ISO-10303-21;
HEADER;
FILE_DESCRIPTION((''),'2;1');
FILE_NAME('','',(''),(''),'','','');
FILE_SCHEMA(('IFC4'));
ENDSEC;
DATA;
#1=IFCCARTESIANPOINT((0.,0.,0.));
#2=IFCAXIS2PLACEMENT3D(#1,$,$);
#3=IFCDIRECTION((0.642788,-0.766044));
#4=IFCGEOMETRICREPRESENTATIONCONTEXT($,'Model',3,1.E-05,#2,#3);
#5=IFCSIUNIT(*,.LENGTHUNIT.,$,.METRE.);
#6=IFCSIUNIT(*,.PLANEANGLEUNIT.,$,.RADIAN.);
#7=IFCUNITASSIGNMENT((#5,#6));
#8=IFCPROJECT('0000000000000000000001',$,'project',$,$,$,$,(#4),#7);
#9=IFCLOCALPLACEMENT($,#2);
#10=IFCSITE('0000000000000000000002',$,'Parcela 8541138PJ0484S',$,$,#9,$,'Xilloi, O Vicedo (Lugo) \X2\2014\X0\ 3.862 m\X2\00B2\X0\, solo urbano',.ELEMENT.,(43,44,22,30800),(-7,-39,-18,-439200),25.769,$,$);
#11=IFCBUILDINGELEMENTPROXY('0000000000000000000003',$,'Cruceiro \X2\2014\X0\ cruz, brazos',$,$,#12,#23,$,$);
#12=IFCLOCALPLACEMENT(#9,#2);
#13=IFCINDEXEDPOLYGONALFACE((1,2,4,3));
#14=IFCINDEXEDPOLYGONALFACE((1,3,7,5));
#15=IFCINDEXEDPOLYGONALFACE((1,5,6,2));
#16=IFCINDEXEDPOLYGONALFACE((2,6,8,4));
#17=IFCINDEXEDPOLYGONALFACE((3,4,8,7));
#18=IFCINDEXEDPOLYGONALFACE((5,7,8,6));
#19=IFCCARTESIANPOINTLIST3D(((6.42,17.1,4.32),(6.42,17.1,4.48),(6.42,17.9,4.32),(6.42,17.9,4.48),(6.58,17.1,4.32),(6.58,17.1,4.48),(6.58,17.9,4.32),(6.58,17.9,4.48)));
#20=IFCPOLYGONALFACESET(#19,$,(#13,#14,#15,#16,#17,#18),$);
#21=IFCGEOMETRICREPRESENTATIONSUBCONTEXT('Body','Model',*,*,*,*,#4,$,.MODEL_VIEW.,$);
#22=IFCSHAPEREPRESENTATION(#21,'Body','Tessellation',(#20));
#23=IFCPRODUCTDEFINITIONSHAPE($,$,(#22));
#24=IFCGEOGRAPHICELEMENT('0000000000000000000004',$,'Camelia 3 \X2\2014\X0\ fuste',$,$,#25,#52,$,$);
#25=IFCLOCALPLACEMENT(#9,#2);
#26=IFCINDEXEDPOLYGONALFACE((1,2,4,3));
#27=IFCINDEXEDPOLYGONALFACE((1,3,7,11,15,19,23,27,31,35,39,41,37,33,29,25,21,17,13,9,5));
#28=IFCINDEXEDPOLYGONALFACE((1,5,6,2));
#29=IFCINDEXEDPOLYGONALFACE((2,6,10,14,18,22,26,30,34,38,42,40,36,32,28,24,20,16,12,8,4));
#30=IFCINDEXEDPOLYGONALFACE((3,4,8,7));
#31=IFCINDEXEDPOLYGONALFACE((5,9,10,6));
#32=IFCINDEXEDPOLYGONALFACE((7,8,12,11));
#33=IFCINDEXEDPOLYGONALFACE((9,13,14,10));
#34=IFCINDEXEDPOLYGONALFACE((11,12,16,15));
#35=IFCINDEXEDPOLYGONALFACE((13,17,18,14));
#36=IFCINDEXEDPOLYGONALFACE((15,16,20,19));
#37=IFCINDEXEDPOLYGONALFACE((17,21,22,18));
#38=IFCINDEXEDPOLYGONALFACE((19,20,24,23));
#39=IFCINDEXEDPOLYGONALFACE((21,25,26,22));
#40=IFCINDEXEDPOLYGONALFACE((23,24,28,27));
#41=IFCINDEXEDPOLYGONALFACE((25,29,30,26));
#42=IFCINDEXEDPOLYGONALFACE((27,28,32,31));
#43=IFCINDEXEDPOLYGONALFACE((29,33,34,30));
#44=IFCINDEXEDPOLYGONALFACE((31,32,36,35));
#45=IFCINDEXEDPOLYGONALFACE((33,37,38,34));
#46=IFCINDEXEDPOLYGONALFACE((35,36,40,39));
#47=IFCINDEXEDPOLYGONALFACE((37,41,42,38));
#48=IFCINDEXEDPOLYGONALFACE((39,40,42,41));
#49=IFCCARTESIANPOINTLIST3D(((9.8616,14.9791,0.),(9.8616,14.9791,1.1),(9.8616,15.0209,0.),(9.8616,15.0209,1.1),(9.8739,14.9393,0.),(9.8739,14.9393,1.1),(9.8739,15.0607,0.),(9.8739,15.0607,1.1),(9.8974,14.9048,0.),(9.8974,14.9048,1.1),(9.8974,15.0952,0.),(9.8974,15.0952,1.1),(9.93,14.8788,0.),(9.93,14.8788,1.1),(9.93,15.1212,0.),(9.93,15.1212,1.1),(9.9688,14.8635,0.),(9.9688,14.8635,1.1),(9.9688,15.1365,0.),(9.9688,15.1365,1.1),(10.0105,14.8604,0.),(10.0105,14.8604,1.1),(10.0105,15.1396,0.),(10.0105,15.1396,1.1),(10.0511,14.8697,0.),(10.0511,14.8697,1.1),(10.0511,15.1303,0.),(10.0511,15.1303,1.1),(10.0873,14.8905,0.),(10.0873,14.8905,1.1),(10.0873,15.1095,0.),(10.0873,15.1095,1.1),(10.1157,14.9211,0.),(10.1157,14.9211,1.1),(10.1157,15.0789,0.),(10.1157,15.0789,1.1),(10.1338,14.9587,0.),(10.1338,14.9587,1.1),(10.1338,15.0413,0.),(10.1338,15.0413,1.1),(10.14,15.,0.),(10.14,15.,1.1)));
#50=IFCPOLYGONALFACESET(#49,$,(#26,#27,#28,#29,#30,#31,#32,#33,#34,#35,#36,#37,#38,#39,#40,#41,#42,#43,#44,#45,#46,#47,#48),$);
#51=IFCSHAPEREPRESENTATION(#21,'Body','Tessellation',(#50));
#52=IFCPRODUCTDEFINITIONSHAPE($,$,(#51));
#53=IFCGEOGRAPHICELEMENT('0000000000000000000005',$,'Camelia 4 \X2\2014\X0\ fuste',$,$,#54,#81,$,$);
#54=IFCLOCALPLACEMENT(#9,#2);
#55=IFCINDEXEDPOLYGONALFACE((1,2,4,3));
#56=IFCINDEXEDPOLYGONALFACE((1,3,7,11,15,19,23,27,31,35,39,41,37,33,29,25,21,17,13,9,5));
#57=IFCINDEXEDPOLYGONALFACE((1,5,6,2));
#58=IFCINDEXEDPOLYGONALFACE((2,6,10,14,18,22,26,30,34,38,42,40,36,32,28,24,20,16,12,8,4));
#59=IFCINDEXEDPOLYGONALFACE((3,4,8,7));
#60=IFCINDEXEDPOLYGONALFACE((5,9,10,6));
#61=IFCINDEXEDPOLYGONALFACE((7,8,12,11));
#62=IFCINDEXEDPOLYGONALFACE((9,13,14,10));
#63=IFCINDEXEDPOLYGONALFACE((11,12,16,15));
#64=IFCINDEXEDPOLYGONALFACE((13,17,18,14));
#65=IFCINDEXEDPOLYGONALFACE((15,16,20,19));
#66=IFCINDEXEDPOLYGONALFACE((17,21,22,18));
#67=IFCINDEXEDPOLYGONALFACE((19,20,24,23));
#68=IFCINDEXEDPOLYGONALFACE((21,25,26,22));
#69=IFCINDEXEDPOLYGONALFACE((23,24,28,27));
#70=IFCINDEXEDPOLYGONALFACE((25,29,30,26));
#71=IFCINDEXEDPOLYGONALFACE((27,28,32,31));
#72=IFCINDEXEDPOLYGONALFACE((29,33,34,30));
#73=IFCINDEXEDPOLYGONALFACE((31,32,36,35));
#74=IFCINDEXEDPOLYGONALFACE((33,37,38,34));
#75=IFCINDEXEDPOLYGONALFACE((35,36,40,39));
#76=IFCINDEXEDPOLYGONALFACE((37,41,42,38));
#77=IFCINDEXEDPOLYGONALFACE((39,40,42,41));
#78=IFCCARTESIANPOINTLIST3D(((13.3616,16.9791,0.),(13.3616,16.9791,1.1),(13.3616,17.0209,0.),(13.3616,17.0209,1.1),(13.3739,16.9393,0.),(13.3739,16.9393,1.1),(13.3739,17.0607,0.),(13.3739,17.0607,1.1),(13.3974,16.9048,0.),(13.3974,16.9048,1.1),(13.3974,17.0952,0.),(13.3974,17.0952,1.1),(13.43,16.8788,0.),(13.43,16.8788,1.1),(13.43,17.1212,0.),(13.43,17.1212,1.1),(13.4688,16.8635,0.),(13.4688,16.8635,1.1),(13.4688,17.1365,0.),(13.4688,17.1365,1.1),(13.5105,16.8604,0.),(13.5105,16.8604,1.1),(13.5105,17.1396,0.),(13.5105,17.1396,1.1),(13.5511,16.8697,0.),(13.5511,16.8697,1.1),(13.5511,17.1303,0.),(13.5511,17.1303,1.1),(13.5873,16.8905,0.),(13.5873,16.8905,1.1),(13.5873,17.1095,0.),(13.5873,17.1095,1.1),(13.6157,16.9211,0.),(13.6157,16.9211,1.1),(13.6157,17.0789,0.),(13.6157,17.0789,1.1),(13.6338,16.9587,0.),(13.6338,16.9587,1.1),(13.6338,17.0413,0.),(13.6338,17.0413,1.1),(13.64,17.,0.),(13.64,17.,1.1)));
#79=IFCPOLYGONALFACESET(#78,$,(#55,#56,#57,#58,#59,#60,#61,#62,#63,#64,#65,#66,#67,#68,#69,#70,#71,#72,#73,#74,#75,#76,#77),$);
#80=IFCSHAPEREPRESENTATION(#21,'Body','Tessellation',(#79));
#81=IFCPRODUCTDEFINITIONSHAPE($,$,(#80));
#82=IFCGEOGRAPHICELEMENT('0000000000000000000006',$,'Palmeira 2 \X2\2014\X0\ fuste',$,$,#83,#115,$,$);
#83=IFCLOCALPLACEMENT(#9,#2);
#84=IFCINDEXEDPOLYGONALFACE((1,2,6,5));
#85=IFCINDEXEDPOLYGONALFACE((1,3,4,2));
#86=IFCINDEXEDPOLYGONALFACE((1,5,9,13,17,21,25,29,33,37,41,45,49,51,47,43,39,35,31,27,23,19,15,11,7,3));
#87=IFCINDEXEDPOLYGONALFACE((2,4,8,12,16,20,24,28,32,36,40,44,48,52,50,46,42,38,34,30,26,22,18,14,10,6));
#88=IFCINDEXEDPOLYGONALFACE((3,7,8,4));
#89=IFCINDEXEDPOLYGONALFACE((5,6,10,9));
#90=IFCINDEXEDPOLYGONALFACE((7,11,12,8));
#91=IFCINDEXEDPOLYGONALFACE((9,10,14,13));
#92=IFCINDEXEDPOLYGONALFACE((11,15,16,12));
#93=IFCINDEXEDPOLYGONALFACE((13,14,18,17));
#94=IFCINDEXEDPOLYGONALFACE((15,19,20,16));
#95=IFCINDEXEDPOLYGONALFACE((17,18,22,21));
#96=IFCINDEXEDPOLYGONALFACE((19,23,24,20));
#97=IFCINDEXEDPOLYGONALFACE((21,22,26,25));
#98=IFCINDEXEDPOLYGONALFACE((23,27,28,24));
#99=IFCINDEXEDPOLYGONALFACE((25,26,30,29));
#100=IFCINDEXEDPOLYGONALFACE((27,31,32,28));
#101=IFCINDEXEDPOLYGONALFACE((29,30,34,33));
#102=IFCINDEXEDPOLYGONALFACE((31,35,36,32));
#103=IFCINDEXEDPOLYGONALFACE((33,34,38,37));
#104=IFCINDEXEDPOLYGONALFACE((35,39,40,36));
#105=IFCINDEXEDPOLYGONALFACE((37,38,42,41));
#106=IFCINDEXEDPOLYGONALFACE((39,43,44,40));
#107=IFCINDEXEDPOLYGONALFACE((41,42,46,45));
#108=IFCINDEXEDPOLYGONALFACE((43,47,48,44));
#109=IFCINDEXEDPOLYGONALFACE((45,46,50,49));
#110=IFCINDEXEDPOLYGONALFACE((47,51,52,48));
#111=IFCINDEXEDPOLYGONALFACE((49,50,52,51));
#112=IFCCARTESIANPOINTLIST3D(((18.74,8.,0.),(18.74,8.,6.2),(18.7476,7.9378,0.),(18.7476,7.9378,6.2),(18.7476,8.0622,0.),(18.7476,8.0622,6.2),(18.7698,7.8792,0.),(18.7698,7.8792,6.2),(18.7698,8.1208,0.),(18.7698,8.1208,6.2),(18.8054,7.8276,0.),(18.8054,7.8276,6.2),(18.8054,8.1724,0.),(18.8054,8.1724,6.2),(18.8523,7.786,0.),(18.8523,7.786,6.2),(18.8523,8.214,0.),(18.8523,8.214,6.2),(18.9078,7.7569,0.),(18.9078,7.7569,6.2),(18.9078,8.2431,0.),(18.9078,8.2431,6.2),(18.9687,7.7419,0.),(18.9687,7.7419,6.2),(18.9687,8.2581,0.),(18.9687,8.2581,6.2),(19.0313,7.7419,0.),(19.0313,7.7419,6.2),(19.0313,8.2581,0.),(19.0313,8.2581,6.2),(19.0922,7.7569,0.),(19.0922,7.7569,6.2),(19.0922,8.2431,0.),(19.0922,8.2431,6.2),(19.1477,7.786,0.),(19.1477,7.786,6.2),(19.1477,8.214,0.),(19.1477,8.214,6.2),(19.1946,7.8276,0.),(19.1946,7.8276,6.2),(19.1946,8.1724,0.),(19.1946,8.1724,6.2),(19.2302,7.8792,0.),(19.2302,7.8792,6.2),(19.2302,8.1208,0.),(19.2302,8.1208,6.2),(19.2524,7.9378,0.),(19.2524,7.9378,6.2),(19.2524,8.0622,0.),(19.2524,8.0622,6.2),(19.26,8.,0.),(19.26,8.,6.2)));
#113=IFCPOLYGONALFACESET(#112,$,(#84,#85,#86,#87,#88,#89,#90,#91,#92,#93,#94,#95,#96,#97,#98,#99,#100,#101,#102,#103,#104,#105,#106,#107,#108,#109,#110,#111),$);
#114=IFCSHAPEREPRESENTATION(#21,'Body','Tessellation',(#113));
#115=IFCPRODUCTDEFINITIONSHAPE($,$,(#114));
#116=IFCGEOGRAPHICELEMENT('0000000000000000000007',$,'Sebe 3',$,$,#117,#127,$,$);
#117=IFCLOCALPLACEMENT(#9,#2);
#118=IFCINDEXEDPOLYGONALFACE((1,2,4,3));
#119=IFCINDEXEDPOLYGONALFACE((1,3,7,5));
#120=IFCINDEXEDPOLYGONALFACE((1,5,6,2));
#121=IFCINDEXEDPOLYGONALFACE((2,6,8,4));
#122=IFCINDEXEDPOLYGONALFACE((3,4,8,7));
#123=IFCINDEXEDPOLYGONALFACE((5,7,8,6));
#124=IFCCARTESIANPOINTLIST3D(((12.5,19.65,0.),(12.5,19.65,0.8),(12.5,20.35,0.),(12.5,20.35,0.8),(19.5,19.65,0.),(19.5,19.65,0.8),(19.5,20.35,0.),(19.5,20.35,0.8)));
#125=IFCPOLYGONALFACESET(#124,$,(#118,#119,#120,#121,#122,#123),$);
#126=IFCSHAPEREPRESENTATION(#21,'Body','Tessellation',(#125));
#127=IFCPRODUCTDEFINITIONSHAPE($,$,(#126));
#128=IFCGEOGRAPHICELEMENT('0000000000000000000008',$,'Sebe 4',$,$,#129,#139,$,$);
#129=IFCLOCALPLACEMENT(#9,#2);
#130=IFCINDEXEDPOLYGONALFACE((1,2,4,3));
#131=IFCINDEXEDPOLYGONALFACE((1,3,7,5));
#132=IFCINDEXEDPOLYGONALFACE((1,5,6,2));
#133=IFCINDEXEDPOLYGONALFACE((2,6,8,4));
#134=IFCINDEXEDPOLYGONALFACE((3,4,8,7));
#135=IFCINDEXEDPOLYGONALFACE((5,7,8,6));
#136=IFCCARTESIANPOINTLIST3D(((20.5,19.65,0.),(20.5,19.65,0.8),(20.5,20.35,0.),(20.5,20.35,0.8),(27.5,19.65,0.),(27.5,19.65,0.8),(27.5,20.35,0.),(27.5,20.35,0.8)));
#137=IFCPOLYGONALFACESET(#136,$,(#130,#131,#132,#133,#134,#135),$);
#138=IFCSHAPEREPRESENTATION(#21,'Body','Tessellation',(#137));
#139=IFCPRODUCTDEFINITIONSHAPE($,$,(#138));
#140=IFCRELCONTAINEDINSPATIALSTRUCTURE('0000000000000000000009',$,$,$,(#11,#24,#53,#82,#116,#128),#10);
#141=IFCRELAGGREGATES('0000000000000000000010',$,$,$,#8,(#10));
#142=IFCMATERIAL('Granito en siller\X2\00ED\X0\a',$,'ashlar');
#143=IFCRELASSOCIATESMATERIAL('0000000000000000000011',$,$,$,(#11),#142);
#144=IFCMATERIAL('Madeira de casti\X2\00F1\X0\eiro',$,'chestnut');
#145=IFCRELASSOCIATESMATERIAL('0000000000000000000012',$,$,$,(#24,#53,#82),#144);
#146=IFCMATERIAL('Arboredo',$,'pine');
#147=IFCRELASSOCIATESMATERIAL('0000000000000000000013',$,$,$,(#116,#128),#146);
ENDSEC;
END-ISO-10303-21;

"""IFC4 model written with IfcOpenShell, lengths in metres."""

from ifc_helpers import new_model, si_unit, direction, frame, origin, origin_2d, place, context, subcontext, project, spatial, rectangle, circle, extrude, material, element, save


model = new_model("IFC4")

# Units and contexts
model_context = context("Model", 3, precision=1e-05, world=origin(), true_north=direction((0.642788, -0.766044)))
body_context = subcontext(model_context, "Body", "Model", "MODEL_VIEW")
ifc_project = project(units=[si_unit("LENGTHUNIT", "METRE"), si_unit("PLANEANGLEUNIT", "RADIAN")], contexts=[model_context])

# Site
site_placement = place(None, origin())
site = spatial("IfcSite", under=ifc_project, at=site_placement, Name="Parcela 8541138PJ0484S", LongName="Xilloi, O Vicedo (Lugo) — 3.862 m², solo urbano", CompositionType="ELEMENT", RefLatitude=(43, 44, 22, 30800), RefLongitude=(-7, -39, -18, -439200), RefElevation=25.769)

# Building element proxy
ifc_material_1 = material(Name="Granito en sillería", Category="ashlar")
proxy_1_placement = place(site_placement, frame((6.5, 17.5, 4.4)))
element("IfcBuildingElementProxy", 1, at=proxy_1_placement, inside=site, material=ifc_material_1, Name="Cruceiro — cruz, brazos", context=body_context, shape_type="SweptSolid", body=[
    extrude(rectangle(XDim=0.16, YDim=0.8, at=origin_2d()), frame((0.0, 0.0, -0.08)), (0.0, 0.0, 1.0), 0.16),
])

# Geographic elements
ifc_material_2 = material(Name="Madeira de castiñeiro", Category="chestnut")
for number, where, name in (
    (2, (10.0, 15.0, 0.55), "Camelia 3 — fuste"),
    (3, (13.5, 17.0, 0.55), "Camelia 4 — fuste"),
):
    element("IfcGeographicElement", number, at=place(site_placement, frame(where)), inside=site, material=ifc_material_2, Name=name, context=body_context, shape_type="SweptSolid", body=[
        extrude(circle(Radius=0.14, at=origin_2d()), frame((0.0, 0.0, -0.55)), (0.0, 0.0, 1.0), 1.1),
    ])
geographic_element_placement = place(site_placement, frame((19.0, 8.0, 3.1)))
element("IfcGeographicElement", 4, at=geographic_element_placement, inside=site, material=ifc_material_2, Name="Palmeira 2 — fuste", context=body_context, shape_type="SweptSolid", body=[
    extrude(circle(Radius=0.26, at=origin_2d()), frame((0.0, 0.0, -3.1)), (0.0, 0.0, 1.0), 6.2),
])
ifc_material_3 = material(Name="Arboredo", Category="pine")
for number, where, name in (
    (5, (16.0, 20.0, 0.4), "Sebe 3"),
    (6, (24.0, 20.0, 0.4), "Sebe 4"),
):
    element("IfcGeographicElement", number, at=place(site_placement, frame(where)), inside=site, material=ifc_material_3, Name=name, context=body_context, shape_type="SweptSolid", body=[
        extrude(rectangle(XDim=7.0, YDim=0.7, at=origin_2d()), frame((0.0, 0.0, -0.4)), (0.0, 0.0, 1.0), 0.8),
    ])

save(model, "model.ifc")
